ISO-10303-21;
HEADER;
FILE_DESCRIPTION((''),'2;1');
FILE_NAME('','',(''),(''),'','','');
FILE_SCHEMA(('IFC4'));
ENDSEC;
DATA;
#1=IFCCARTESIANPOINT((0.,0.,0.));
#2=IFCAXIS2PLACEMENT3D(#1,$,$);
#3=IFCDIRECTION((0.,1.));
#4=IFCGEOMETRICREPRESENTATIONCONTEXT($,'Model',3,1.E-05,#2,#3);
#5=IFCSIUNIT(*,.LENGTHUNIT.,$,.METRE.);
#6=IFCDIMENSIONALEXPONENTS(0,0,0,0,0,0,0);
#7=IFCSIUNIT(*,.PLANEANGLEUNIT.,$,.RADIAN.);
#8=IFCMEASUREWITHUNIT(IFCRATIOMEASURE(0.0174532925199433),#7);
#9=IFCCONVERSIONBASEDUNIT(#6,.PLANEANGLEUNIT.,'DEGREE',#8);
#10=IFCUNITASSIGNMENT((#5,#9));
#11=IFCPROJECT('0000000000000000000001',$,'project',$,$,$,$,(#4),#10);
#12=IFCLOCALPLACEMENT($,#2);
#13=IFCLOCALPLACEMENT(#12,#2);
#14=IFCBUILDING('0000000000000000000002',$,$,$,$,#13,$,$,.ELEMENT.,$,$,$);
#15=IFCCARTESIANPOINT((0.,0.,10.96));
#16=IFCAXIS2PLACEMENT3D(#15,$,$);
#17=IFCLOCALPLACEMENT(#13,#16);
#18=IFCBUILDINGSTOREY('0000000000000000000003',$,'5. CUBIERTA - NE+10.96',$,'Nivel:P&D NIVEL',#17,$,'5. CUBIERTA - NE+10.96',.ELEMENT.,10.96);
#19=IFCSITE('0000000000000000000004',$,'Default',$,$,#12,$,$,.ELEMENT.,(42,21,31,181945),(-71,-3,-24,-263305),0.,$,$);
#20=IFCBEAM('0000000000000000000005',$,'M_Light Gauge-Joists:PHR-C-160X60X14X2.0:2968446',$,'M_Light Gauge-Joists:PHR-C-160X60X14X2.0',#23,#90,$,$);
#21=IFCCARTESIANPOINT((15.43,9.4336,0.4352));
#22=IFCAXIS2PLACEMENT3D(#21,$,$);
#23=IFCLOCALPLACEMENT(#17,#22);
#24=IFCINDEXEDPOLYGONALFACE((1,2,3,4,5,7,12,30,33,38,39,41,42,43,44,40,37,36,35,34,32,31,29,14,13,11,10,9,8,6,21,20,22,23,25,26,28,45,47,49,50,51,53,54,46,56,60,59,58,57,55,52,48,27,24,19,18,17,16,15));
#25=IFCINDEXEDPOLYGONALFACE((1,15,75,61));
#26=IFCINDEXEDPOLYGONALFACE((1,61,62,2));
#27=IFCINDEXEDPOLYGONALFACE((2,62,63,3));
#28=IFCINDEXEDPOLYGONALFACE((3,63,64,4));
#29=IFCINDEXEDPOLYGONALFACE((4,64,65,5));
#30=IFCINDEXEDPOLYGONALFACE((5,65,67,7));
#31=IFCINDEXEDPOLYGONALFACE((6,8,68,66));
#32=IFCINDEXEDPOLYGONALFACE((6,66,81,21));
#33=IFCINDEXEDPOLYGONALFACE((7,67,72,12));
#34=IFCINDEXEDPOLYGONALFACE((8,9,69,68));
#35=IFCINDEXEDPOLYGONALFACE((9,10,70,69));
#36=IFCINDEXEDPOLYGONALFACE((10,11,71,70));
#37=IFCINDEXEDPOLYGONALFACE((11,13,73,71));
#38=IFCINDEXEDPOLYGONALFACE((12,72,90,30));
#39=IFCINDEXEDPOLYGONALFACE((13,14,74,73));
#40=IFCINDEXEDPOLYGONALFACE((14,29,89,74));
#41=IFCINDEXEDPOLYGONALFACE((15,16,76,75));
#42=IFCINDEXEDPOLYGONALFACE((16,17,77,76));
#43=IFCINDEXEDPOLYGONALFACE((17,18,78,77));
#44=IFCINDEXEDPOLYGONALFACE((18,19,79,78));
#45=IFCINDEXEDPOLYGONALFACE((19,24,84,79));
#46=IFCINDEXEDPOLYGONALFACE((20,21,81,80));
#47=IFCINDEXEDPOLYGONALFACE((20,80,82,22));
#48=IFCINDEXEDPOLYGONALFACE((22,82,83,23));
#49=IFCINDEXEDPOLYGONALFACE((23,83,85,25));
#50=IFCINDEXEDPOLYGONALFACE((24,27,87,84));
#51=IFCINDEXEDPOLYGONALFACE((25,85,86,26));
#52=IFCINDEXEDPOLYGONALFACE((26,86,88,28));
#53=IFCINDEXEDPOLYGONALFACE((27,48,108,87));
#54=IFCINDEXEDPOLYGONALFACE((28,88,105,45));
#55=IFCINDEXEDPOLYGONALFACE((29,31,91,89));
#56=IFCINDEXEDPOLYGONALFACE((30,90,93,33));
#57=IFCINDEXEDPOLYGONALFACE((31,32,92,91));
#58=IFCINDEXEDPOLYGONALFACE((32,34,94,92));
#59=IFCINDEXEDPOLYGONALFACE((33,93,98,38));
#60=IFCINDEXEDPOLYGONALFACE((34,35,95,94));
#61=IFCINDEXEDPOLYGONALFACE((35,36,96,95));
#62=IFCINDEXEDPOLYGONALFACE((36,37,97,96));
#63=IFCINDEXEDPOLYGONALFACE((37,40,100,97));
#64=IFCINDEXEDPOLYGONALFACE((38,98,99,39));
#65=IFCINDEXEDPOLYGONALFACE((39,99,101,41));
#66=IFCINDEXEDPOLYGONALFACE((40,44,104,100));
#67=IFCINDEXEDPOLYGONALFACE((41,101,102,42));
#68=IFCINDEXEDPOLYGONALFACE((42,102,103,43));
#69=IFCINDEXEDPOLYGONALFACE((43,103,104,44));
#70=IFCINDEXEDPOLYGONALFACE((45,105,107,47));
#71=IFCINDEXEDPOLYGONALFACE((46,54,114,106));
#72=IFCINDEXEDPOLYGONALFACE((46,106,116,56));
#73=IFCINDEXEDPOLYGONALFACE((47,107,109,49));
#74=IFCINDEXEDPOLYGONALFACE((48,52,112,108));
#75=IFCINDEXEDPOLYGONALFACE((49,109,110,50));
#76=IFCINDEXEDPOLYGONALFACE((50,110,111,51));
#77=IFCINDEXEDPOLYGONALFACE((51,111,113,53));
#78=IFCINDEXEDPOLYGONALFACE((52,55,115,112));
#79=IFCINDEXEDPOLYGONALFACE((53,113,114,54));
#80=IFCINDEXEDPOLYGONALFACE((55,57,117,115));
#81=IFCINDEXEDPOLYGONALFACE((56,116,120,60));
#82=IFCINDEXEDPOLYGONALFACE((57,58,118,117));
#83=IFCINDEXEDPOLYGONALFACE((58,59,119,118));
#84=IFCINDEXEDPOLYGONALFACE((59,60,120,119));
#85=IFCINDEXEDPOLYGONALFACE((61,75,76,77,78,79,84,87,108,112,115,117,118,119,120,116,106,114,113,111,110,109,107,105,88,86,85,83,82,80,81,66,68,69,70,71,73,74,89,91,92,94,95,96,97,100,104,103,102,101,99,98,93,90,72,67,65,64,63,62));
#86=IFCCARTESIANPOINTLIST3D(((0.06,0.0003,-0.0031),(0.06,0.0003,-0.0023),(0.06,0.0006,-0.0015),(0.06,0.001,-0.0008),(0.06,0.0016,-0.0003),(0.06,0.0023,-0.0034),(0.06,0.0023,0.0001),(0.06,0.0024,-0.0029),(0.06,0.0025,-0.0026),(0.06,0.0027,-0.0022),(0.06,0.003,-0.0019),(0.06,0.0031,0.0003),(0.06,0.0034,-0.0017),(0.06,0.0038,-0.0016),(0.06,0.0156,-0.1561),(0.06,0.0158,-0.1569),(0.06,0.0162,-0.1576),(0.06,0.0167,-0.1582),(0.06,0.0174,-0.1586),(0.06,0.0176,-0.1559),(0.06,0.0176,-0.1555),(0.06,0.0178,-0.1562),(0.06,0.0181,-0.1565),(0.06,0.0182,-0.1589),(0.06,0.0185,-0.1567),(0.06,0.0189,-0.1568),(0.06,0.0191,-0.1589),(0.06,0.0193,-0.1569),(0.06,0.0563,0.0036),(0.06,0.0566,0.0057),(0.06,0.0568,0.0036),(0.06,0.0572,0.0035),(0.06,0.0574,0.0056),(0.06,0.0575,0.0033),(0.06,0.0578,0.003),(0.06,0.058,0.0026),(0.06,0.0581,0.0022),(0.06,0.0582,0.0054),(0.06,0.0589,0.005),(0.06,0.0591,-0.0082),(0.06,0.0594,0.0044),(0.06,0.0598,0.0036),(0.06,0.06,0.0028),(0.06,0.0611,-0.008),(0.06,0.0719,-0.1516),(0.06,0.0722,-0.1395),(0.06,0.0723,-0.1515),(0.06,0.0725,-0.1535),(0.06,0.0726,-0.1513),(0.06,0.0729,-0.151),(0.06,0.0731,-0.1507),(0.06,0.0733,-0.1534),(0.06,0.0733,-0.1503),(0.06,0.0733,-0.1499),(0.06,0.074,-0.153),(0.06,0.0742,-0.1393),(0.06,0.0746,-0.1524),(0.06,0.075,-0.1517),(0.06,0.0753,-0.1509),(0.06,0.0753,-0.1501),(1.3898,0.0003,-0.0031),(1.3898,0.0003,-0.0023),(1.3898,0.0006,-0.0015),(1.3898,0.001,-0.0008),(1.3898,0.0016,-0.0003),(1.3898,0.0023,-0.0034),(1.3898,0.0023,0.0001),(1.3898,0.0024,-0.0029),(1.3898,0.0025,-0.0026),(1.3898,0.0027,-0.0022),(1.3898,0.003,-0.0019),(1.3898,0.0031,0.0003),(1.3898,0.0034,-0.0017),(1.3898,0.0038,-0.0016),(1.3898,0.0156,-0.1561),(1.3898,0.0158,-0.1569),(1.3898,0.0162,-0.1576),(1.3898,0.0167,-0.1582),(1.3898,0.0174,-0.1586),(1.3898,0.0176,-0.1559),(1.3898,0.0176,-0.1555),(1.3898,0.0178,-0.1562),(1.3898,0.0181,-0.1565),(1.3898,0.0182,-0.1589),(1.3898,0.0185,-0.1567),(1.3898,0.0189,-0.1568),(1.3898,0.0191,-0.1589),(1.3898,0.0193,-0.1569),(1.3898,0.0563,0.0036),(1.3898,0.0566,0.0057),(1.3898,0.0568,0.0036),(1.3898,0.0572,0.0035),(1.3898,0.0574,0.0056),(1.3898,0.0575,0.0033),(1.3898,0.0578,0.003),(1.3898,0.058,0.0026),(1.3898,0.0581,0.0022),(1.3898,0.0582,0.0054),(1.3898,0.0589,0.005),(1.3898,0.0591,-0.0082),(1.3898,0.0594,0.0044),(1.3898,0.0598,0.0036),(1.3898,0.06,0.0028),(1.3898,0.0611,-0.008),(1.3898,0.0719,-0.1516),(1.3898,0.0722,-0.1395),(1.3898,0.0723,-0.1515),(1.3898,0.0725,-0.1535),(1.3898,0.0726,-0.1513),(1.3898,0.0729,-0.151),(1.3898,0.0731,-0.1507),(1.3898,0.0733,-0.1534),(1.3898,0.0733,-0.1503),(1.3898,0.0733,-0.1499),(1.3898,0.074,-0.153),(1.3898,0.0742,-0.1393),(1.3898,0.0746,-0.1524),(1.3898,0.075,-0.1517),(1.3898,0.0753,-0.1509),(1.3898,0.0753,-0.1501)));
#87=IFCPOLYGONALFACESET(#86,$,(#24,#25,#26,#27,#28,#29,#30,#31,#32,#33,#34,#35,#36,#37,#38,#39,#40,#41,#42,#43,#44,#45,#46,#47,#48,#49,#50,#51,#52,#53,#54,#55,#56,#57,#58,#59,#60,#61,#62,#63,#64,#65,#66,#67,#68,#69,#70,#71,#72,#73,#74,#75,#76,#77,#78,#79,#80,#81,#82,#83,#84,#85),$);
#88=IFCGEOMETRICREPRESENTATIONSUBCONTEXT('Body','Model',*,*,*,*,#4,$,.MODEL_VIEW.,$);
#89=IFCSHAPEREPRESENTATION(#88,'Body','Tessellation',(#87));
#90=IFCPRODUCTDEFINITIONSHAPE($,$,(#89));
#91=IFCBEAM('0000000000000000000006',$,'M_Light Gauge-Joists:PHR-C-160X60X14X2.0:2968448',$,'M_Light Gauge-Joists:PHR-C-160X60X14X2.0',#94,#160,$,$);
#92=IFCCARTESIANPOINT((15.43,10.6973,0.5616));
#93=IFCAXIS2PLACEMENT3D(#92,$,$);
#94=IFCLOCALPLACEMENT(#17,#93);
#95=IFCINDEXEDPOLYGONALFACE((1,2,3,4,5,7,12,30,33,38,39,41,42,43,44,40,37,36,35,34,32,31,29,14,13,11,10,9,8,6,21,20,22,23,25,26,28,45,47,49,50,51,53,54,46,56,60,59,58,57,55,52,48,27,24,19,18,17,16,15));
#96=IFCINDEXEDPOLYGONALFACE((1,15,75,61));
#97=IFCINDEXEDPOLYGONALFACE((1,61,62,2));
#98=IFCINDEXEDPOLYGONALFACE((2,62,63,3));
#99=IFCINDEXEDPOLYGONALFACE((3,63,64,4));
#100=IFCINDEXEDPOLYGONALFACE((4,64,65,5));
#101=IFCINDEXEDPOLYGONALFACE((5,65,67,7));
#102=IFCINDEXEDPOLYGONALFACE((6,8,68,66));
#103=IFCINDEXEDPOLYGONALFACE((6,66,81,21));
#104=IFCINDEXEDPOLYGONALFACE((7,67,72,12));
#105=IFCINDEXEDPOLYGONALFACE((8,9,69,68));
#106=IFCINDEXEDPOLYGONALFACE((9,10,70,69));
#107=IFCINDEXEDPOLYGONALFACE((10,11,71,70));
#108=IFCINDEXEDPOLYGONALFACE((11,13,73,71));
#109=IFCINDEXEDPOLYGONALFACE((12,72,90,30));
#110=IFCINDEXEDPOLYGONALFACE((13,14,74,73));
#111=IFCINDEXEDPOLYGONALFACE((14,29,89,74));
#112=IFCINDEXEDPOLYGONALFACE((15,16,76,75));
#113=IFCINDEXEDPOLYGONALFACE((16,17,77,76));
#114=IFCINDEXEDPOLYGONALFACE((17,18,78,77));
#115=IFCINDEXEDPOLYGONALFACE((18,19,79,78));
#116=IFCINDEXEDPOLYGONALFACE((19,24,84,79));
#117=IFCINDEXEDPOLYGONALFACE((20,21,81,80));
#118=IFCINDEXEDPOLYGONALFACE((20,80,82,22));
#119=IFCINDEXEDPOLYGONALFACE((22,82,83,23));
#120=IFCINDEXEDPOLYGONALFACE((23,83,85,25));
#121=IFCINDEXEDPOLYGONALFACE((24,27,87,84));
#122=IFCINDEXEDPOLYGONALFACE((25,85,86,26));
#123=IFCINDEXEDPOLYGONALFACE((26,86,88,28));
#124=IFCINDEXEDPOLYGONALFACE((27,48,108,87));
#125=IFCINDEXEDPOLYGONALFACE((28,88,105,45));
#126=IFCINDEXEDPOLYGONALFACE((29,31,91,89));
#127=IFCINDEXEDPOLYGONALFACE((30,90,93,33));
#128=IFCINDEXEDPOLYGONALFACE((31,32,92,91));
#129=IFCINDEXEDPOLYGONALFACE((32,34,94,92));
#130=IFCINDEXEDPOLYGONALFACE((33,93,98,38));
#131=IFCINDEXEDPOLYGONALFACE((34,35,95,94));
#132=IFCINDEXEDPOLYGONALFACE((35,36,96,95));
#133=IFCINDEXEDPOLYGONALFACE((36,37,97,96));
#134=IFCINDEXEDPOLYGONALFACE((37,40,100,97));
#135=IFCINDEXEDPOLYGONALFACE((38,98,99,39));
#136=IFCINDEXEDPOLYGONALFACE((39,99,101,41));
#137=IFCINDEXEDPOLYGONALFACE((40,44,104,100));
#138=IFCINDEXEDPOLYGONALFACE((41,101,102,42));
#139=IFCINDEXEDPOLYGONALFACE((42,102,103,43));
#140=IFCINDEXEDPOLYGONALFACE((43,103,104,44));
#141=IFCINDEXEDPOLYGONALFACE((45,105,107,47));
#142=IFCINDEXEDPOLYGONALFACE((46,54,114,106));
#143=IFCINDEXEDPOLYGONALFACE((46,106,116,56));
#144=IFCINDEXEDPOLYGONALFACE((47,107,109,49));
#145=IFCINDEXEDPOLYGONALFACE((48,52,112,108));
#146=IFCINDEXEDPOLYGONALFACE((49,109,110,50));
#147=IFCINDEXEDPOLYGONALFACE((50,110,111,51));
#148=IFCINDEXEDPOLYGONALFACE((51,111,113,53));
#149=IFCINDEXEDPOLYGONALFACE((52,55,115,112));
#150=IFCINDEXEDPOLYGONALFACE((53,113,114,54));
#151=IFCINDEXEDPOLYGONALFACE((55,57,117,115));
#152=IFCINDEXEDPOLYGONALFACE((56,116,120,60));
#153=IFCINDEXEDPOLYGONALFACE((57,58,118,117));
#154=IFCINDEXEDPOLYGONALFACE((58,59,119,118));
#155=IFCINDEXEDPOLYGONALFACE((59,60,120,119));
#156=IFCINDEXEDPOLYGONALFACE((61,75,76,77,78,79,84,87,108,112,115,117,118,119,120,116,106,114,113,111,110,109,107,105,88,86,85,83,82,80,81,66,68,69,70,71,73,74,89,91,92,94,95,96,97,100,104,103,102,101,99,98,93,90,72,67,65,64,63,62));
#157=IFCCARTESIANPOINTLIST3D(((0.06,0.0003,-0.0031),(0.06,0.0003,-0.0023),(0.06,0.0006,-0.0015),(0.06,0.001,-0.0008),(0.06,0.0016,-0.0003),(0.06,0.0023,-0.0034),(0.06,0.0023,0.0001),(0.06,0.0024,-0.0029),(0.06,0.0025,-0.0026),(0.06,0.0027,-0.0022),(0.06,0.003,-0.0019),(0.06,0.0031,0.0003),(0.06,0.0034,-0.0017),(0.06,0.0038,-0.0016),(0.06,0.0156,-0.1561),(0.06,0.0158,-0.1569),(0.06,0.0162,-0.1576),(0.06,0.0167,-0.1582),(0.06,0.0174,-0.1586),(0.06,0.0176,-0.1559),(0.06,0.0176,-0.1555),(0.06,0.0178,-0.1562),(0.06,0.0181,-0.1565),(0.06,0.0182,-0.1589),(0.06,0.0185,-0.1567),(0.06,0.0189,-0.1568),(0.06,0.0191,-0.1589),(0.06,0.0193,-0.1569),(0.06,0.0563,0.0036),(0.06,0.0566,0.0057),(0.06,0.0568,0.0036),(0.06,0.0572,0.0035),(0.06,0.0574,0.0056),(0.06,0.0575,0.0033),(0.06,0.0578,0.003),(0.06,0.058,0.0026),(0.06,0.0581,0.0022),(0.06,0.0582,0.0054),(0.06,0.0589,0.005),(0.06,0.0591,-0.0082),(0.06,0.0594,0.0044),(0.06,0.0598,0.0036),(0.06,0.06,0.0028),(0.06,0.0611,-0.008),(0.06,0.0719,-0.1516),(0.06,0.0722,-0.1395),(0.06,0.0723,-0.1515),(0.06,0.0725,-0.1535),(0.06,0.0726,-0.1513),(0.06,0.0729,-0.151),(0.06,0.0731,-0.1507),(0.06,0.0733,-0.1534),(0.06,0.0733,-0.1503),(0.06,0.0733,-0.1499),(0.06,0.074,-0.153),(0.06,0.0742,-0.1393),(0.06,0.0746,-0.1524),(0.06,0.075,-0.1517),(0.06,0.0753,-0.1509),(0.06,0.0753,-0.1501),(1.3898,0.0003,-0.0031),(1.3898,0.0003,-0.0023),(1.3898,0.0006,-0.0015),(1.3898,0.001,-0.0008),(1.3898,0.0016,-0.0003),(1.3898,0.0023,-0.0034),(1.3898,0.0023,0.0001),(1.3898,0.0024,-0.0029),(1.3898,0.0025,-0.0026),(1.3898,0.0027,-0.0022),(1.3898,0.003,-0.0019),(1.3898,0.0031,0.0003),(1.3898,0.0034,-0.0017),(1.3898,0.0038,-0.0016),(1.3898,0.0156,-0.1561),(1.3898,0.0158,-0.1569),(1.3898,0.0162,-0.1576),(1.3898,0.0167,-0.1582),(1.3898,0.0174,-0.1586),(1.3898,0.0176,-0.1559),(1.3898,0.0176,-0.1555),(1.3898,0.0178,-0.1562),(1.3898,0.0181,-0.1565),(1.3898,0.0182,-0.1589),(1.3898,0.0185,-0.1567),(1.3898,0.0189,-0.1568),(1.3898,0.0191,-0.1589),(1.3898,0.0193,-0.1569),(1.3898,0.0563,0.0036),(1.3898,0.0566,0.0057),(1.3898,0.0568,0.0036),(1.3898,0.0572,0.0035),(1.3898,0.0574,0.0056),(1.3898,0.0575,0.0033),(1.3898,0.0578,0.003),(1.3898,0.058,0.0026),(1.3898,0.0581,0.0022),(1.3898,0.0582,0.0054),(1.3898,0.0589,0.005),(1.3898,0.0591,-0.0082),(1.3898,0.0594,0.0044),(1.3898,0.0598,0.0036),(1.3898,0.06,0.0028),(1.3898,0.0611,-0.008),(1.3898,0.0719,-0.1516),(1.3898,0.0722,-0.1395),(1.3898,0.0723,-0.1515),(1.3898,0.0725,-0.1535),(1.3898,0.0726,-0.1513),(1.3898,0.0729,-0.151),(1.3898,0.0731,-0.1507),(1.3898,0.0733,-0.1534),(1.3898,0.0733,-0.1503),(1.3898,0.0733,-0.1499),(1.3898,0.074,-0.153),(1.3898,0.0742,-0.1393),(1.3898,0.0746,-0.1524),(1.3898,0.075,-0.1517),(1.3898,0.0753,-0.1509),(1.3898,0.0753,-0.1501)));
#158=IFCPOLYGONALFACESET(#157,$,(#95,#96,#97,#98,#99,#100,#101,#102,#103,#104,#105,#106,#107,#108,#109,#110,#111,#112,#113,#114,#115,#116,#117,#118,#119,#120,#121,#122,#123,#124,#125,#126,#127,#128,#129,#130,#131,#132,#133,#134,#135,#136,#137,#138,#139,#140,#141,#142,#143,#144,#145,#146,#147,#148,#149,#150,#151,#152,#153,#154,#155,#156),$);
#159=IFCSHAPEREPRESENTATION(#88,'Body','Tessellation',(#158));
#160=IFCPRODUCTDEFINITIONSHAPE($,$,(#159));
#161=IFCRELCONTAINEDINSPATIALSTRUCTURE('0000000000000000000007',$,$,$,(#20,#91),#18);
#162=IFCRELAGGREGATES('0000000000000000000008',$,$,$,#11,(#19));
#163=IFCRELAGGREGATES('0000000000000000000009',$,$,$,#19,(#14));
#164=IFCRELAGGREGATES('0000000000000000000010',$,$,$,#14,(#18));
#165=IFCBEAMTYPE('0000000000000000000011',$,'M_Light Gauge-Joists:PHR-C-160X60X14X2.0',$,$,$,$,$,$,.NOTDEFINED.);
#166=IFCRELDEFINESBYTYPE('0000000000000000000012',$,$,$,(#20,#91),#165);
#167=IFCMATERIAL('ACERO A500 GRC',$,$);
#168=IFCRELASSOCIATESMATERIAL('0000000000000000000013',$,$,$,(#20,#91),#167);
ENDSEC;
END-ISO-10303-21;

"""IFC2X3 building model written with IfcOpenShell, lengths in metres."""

from ifc_helpers import new_model, entity, si_unit, converted_unit, direction, frame, frame_2d, origin, place, context, subcontext, project, spatial, polyline, circle_curve, parameter, trimmed, segment, composite_curve, outline, extrude, material, type_object, element, save


model = new_model("IFC2X3")

# Units and contexts
model_context = context("Model", 3, precision=1e-05, world=origin(), true_north=direction((0.0, 1.0)))
body_context = subcontext(model_context, "Body", "Model", "MODEL_VIEW")
ifc_project = project(units=[si_unit("LENGTHUNIT", "METRE"), converted_unit("PLANEANGLEUNIT", "DEGREE", entity("IfcRatioMeasure", 0.0174532925199433), si_unit("PLANEANGLEUNIT", "RADIAN"), dimensions=[0, 0, 0, 0, 0, 0, 0])], contexts=[model_context])

# Site, building, storey
site_placement = place(None, origin())
site = spatial("IfcSite", under=ifc_project, at=site_placement, Name="Default", CompositionType="ELEMENT", RefLatitude=(42, 21, 31, 181945), RefLongitude=(-71, -3, -24, -263305), RefElevation=0.0)
building_placement = place(site_placement, origin())
building = spatial("IfcBuilding", under=site, at=building_placement, CompositionType="ELEMENT")
storey_placement = place(building_placement, frame((0.0, 0.0, 10.96)))
storey = spatial("IfcBuildingStorey", under=building, at=storey_placement, Name="5. CUBIERTA - NE+10.96", ObjectType="Nivel:P&D NIVEL", LongName="5. CUBIERTA - NE+10.96", CompositionType="ELEMENT", Elevation=10.96)

# Beams
ifc_material_1 = material(Name="ACERO A500 GRC")
beam_type_1 = type_object("IfcBeamType", Name="M_Light Gauge-Joists:PHR-C-160X60X14X2.0", PredefinedType="NOTDEFINED")
beam_1_placement = place(storey_placement, frame((15.43, 9.4336, 0.4352)))
element("IfcBeam", 1, at=beam_1_placement, inside=storey, type_object=beam_type_1, material=ifc_material_1, Name="M_Light Gauge-Joists:PHR-C-160X60X14X2.0:2968446", ObjectType="M_Light Gauge-Joists:PHR-C-160X60X14X2.0", context=body_context, shape_type="SweptSolid", body=[
    extrude(outline(composite_curve([segment(trimmed(circle_curve(frame_2d((-0.0764, -0.0322), x_axis=(-1.0, 0.0)), 0.0016), [parameter(0.0)], [parameter(90.0)], True, "PARAMETER"), False, "CONTINUOUS"), segment(polyline([(-0.078, -0.0322), (-0.078, 0.0206)]), True, "CONTINUOUS"), segment(trimmed(circle_curve(frame_2d((-0.0764, 0.0206), x_axis=(0.0, 1.0)), 0.0016), [parameter(0.0)], [parameter(90.0)], True, "PARAMETER"), False, "CONTINUOUS"), segment(polyline([(-0.0764, 0.0222), (-0.066, 0.0222)]), True, "CONTINUOUS"), segment(polyline([(-0.066, 0.0222), (-0.066, 0.0242)]), True, "CONTINUOUS"), segment(polyline([(-0.066, 0.0242), (-0.0768, 0.0242)]), True, "CONTINUOUS"), segment(trimmed(circle_curve(frame_2d((-0.0768, 0.021), x_axis=(-1.0, 0.0)), 0.0032), [parameter(270.0)], [parameter(0.0)], True, "PARAMETER"), True, "CONTINUOUS"), segment(polyline([(-0.08, 0.021), (-0.08, -0.0326)]), True, "CONTINUOUS"), segment(trimmed(circle_curve(frame_2d((-0.0768, -0.0326), x_axis=(0.0, -1.0)), 0.0032), [parameter(270.0)], [parameter(0.0)], True, "PARAMETER"), True, "CONTINUOUS"), segment(polyline([(-0.0768, -0.0358), (0.0768, -0.0358)]), True, "CONTINUOUS"), segment(trimmed(circle_curve(frame_2d((0.0768, -0.0326), x_axis=(1.0, 0.0)), 0.0032), [parameter(270.0)], [parameter(0.0)], True, "PARAMETER"), True, "CONTINUOUS"), segment(polyline([(0.08, -0.0326), (0.08, 0.021)]), True, "CONTINUOUS"), segment(trimmed(circle_curve(frame_2d((0.0768, 0.021), x_axis=(0.0, 1.0)), 0.0032), [parameter(270.0)], [parameter(0.0)], True, "PARAMETER"), True, "CONTINUOUS"), segment(polyline([(0.0768, 0.0242), (0.066, 0.0242)]), True, "CONTINUOUS"), segment(polyline([(0.066, 0.0242), (0.066, 0.0222)]), True, "CONTINUOUS"), segment(polyline([(0.066, 0.0222), (0.0764, 0.0222)]), True, "CONTINUOUS"), segment(trimmed(circle_curve(frame_2d((0.0764, 0.0206), x_axis=(1.0, 0.0)), 0.0016), [parameter(0.0)], [parameter(90.0)], True, "PARAMETER"), False, "CONTINUOUS"), segment(polyline([(0.078, 0.0206), (0.078, -0.0322)]), True, "CONTINUOUS"), segment(trimmed(circle_curve(frame_2d((0.0764, -0.0322), x_axis=(0.0, -1.0)), 0.0016), [parameter(0.0)], [parameter(90.0)], True, "PARAMETER"), False, "CONTINUOUS"), segment(polyline([(0.0764, -0.0338), (-0.0764, -0.0338)]), True, "CONTINUOUS")], self_intersect=False)), frame((0.06, 0.0436, -0.076), z_axis=(-1.0, 0.0, 0.0), x_axis=(0.0, -0.099504, 0.995037)), (0.0, 0.0, -1.0), 1.3298),
])
beam_2_placement = place(storey_placement, frame((15.43, 10.6973, 0.5616)))
element("IfcBeam", 2, at=beam_2_placement, inside=storey, type_object=beam_type_1, material=ifc_material_1, Name="M_Light Gauge-Joists:PHR-C-160X60X14X2.0:2968448", ObjectType="M_Light Gauge-Joists:PHR-C-160X60X14X2.0", context=body_context, shape_type="SweptSolid", body=[
    extrude(outline(composite_curve([segment(trimmed(circle_curve(frame_2d((-0.0764, -0.0322), x_axis=(-1.0, 0.0)), 0.0016), [parameter(0.0)], [parameter(90.0)], True, "PARAMETER"), False, "CONTINUOUS"), segment(polyline([(-0.078, -0.0322), (-0.078, 0.0206)]), True, "CONTINUOUS"), segment(trimmed(circle_curve(frame_2d((-0.0764, 0.0206), x_axis=(0.0, 1.0)), 0.0016), [parameter(0.0)], [parameter(90.0)], True, "PARAMETER"), False, "CONTINUOUS"), segment(polyline([(-0.0764, 0.0222), (-0.066, 0.0222)]), True, "CONTINUOUS"), segment(polyline([(-0.066, 0.0222), (-0.066, 0.0242)]), True, "CONTINUOUS"), segment(polyline([(-0.066, 0.0242), (-0.0768, 0.0242)]), True, "CONTINUOUS"), segment(trimmed(circle_curve(frame_2d((-0.0768, 0.021), x_axis=(-1.0, 0.0)), 0.0032), [parameter(270.0)], [parameter(0.0)], True, "PARAMETER"), True, "CONTINUOUS"), segment(polyline([(-0.08, 0.021), (-0.08, -0.0326)]), True, "CONTINUOUS"), segment(trimmed(circle_curve(frame_2d((-0.0768, -0.0326), x_axis=(0.0, -1.0)), 0.0032), [parameter(270.0)], [parameter(0.0)], True, "PARAMETER"), True, "CONTINUOUS"), segment(polyline([(-0.0768, -0.0358), (0.0768, -0.0358)]), True, "CONTINUOUS"), segment(trimmed(circle_curve(frame_2d((0.0768, -0.0326), x_axis=(1.0, 0.0)), 0.0032), [parameter(270.0)], [parameter(0.0)], True, "PARAMETER"), True, "CONTINUOUS"), segment(polyline([(0.08, -0.0326), (0.08, 0.021)]), True, "CONTINUOUS"), segment(trimmed(circle_curve(frame_2d((0.0768, 0.021), x_axis=(0.0, 1.0)), 0.0032), [parameter(270.0)], [parameter(0.0)], True, "PARAMETER"), True, "CONTINUOUS"), segment(polyline([(0.0768, 0.0242), (0.066, 0.0242)]), True, "CONTINUOUS"), segment(polyline([(0.066, 0.0242), (0.066, 0.0222)]), True, "CONTINUOUS"), segment(polyline([(0.066, 0.0222), (0.0764, 0.0222)]), True, "CONTINUOUS"), segment(trimmed(circle_curve(frame_2d((0.0764, 0.0206), x_axis=(1.0, 0.0)), 0.0016), [parameter(0.0)], [parameter(90.0)], True, "PARAMETER"), False, "CONTINUOUS"), segment(polyline([(0.078, 0.0206), (0.078, -0.0322)]), True, "CONTINUOUS"), segment(trimmed(circle_curve(frame_2d((0.0764, -0.0322), x_axis=(0.0, -1.0)), 0.0016), [parameter(0.0)], [parameter(90.0)], True, "PARAMETER"), False, "CONTINUOUS"), segment(polyline([(0.0764, -0.0338), (-0.0764, -0.0338)]), True, "CONTINUOUS")], self_intersect=False)), frame((0.06, 0.0436, -0.076), z_axis=(-1.0, 0.0, 0.0), x_axis=(0.0, -0.099504, 0.995037)), (0.0, 0.0, -1.0), 1.3298),
])

save(model, "model.ifc")
